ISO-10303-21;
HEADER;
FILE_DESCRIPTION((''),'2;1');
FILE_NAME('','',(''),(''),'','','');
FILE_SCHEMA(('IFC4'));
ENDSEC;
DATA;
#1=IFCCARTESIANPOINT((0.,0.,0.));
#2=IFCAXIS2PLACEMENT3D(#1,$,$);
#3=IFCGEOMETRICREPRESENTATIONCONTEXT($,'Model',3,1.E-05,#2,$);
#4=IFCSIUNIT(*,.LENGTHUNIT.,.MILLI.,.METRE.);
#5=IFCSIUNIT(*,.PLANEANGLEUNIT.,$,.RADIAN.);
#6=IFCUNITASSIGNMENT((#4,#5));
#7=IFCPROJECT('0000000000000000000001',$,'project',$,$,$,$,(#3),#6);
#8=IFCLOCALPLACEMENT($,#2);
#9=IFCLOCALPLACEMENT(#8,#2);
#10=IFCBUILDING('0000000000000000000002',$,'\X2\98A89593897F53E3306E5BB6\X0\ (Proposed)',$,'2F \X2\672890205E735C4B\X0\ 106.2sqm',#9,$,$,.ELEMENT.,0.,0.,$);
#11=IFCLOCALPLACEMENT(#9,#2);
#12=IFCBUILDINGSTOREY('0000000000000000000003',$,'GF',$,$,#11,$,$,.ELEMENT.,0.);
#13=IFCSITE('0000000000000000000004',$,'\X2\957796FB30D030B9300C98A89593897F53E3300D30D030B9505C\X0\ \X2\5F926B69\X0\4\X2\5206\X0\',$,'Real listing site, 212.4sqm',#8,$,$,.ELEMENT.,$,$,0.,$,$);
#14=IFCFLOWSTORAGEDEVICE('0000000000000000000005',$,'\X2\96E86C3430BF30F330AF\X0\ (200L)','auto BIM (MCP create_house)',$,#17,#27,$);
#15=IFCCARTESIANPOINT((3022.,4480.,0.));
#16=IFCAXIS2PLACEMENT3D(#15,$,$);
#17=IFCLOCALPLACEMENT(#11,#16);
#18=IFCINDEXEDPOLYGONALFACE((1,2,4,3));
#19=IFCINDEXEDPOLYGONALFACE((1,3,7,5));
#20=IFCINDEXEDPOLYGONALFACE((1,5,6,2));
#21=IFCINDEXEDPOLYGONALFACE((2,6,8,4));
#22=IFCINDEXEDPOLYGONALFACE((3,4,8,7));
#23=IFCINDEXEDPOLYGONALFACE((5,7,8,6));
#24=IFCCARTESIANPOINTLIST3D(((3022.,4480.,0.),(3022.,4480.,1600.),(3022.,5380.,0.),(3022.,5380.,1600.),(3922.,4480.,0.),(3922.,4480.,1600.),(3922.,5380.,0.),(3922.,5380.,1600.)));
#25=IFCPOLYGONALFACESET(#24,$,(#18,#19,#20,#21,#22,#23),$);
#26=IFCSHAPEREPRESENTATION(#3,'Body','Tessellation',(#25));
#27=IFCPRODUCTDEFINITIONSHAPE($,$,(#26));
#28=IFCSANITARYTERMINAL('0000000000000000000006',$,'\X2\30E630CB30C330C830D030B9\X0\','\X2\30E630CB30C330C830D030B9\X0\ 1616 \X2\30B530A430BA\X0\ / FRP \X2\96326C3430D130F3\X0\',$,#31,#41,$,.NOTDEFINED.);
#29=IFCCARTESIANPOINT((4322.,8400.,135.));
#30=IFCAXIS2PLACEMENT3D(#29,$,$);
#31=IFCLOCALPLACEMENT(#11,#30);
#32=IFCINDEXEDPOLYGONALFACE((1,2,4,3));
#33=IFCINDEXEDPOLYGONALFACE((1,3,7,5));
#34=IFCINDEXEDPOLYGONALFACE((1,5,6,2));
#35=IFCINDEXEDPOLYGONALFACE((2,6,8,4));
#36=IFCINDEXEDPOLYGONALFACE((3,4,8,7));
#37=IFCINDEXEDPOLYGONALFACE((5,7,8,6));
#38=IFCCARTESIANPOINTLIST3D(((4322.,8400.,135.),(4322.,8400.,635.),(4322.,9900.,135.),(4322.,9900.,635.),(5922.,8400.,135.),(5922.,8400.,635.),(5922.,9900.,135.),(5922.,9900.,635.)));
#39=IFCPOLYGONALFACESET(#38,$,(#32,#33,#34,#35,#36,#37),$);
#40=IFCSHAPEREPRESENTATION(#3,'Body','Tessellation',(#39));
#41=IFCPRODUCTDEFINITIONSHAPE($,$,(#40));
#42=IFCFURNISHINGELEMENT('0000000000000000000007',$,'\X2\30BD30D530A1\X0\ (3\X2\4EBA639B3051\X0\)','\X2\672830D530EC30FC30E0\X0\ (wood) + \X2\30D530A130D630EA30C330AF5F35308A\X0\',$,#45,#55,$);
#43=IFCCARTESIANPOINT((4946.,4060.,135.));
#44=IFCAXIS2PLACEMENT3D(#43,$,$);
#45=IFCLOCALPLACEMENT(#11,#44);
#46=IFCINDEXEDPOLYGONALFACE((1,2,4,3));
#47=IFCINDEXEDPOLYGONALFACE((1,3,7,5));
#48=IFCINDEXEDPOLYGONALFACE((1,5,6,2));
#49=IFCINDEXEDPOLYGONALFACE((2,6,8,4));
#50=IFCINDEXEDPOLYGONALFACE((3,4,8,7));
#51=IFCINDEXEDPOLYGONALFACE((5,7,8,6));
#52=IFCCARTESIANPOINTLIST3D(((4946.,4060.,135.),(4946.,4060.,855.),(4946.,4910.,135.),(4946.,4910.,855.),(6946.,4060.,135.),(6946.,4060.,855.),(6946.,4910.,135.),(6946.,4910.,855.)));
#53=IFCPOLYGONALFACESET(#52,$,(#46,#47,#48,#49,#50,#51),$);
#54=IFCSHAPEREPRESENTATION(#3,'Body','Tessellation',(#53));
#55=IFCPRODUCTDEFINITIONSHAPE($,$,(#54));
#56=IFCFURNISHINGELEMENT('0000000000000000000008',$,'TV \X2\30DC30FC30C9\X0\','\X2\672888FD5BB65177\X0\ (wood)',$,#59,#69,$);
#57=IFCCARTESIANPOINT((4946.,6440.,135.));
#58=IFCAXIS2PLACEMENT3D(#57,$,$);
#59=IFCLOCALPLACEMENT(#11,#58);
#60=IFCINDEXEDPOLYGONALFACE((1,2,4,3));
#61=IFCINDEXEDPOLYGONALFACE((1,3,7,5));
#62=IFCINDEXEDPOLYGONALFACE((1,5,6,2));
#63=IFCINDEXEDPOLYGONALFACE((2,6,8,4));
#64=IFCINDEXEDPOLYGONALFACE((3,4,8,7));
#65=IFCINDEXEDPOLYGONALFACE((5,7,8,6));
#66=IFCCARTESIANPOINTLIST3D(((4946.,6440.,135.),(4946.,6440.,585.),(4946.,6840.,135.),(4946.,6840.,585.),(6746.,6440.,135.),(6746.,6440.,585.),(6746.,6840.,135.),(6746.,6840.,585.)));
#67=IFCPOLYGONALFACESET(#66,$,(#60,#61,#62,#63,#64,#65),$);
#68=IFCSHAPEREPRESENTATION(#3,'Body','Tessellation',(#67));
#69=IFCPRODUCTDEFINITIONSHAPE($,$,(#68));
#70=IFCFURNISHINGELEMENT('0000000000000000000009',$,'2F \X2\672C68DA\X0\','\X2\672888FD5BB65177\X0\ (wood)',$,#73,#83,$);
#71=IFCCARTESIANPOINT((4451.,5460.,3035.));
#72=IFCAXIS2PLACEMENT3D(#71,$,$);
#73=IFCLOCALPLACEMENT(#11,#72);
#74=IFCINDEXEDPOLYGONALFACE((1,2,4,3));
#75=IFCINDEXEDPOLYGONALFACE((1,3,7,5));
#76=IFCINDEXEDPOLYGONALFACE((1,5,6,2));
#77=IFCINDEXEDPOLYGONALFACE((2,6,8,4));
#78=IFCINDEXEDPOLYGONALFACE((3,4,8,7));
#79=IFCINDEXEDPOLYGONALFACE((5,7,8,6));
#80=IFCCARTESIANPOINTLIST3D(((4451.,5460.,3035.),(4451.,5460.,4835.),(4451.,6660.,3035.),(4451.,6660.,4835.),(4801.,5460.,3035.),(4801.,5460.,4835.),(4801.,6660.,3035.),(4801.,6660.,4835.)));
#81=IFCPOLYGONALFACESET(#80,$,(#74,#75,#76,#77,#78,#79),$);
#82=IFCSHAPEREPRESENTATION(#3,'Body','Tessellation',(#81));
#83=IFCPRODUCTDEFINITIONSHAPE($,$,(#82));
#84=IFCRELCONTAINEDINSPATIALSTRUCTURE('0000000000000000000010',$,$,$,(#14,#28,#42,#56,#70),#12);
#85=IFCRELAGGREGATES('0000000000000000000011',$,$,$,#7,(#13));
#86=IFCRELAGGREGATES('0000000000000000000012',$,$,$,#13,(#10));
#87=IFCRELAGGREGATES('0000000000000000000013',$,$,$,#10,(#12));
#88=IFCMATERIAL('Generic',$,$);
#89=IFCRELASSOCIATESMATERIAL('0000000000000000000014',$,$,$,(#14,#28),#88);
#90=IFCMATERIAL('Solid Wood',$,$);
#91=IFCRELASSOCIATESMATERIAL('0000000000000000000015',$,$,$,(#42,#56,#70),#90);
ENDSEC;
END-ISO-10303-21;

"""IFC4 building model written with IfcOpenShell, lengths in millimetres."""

from ifc_helpers import new_model, si_unit, frame, frame_2d, origin, place, context, project, spatial, rectangle, extrude, material, element, save


model = new_model("IFC4")

# Units and contexts
model_context = context("Model", 3, precision=1e-05, world=origin())
ifc_project = project(units=[si_unit("LENGTHUNIT", "METRE", prefix="MILLI"), si_unit("PLANEANGLEUNIT", "RADIAN")], contexts=[model_context])

# Site, building, storey
site_placement = place(None, origin())
site = spatial("IfcSite", under=ifc_project, at=site_placement, Name="長電バス「風間西口」バス停 徒歩4分", ObjectType="Real listing site, 212.4sqm", CompositionType="ELEMENT", RefElevation=0.0)
building_placement = place(site_placement, origin())
building = spatial("IfcBuilding", under=site, at=building_placement, Name="風間西口の家 (Proposed)", ObjectType="2F 木造平屋 106.2sqm", CompositionType="ELEMENT", ElevationOfRefHeight=0.0, ElevationOfTerrain=0.0)
storey_placement = place(building_placement, origin())
storey = spatial("IfcBuildingStorey", under=building, at=storey_placement, Name="GF", CompositionType="ELEMENT", Elevation=0.0)

# Shared definitions
ifc_material_1 = material(Name="Solid Wood")

# Shared definitions
ifc_material_2 = material(Name="Generic")

# Flow storage device
flow_storage_device_placement = place(storey_placement, frame((3022.0, 4480.0, 0.0)))
element("IfcFlowStorageDevice", 1, at=flow_storage_device_placement, inside=storey, material=ifc_material_2, Name="雨水タンク (200L)", Description="auto BIM (MCP create_house)", context=model_context, shape_type="SweptSolid", body=[
    extrude(rectangle(XDim=900.0, YDim=900.0, at=frame_2d((450.0, 450.0))), frame((3022.0, 4480.0, 0.0)), (0.0, 0.0, 1.0), 1600.0),
])

# Sanitary terminal
sanitary_terminal_placement = place(storey_placement, frame((4322.0, 8400.0, 135.0)))
element("IfcSanitaryTerminal", 2, at=sanitary_terminal_placement, inside=storey, material=ifc_material_2, Name="ユニットバス", Description="ユニットバス 1616 サイズ / FRP 防水パン", PredefinedType="NOTDEFINED", context=model_context, shape_type="SweptSolid", body=[
    extrude(rectangle(XDim=1600.0, YDim=1500.0, at=frame_2d((800.0, 750.0))), frame((4322.0, 8400.0, 135.0)), (0.0, 0.0, 1.0), 500.0),
])

# Furnishing elements
furnishing_1_placement = place(storey_placement, frame((4946.0, 4060.0, 135.0)))
element("IfcFurnishingElement", 3, at=furnishing_1_placement, inside=storey, material=ifc_material_1, Name="ソファ (3人掛け)", Description="木フレーム (wood) + ファブリック張り", context=model_context, shape_type="SweptSolid", body=[
    extrude(rectangle(XDim=2000.0, YDim=850.0, at=frame_2d((1000.0, 425.0))), frame((4946.0, 4060.0, 135.0)), (0.0, 0.0, 1.0), 720.0),
])
furnishing_2_placement = place(storey_placement, frame((4946.0, 6440.0, 135.0)))
element("IfcFurnishingElement", 4, at=furnishing_2_placement, inside=storey, material=ifc_material_1, Name="TV ボード", Description="木製家具 (wood)", context=model_context, shape_type="SweptSolid", body=[
    extrude(rectangle(XDim=1800.0, YDim=400.0, at=frame_2d((900.0, 200.0))), frame((4946.0, 6440.0, 135.0)), (0.0, 0.0, 1.0), 450.0),
])
furnishing_3_placement = place(storey_placement, frame((4451.0, 5460.0, 3035.0)))
element("IfcFurnishingElement", 5, at=furnishing_3_placement, inside=storey, material=ifc_material_1, Name="2F 本棚", Description="木製家具 (wood)", context=model_context, shape_type="SweptSolid", body=[
    extrude(rectangle(XDim=350.0, YDim=1200.0, at=frame_2d((175.0, 600.0))), frame((4451.0, 5460.0, 3035.0)), (0.0, 0.0, 1.0), 1800.0),
])

save(model, "model.ifc")
